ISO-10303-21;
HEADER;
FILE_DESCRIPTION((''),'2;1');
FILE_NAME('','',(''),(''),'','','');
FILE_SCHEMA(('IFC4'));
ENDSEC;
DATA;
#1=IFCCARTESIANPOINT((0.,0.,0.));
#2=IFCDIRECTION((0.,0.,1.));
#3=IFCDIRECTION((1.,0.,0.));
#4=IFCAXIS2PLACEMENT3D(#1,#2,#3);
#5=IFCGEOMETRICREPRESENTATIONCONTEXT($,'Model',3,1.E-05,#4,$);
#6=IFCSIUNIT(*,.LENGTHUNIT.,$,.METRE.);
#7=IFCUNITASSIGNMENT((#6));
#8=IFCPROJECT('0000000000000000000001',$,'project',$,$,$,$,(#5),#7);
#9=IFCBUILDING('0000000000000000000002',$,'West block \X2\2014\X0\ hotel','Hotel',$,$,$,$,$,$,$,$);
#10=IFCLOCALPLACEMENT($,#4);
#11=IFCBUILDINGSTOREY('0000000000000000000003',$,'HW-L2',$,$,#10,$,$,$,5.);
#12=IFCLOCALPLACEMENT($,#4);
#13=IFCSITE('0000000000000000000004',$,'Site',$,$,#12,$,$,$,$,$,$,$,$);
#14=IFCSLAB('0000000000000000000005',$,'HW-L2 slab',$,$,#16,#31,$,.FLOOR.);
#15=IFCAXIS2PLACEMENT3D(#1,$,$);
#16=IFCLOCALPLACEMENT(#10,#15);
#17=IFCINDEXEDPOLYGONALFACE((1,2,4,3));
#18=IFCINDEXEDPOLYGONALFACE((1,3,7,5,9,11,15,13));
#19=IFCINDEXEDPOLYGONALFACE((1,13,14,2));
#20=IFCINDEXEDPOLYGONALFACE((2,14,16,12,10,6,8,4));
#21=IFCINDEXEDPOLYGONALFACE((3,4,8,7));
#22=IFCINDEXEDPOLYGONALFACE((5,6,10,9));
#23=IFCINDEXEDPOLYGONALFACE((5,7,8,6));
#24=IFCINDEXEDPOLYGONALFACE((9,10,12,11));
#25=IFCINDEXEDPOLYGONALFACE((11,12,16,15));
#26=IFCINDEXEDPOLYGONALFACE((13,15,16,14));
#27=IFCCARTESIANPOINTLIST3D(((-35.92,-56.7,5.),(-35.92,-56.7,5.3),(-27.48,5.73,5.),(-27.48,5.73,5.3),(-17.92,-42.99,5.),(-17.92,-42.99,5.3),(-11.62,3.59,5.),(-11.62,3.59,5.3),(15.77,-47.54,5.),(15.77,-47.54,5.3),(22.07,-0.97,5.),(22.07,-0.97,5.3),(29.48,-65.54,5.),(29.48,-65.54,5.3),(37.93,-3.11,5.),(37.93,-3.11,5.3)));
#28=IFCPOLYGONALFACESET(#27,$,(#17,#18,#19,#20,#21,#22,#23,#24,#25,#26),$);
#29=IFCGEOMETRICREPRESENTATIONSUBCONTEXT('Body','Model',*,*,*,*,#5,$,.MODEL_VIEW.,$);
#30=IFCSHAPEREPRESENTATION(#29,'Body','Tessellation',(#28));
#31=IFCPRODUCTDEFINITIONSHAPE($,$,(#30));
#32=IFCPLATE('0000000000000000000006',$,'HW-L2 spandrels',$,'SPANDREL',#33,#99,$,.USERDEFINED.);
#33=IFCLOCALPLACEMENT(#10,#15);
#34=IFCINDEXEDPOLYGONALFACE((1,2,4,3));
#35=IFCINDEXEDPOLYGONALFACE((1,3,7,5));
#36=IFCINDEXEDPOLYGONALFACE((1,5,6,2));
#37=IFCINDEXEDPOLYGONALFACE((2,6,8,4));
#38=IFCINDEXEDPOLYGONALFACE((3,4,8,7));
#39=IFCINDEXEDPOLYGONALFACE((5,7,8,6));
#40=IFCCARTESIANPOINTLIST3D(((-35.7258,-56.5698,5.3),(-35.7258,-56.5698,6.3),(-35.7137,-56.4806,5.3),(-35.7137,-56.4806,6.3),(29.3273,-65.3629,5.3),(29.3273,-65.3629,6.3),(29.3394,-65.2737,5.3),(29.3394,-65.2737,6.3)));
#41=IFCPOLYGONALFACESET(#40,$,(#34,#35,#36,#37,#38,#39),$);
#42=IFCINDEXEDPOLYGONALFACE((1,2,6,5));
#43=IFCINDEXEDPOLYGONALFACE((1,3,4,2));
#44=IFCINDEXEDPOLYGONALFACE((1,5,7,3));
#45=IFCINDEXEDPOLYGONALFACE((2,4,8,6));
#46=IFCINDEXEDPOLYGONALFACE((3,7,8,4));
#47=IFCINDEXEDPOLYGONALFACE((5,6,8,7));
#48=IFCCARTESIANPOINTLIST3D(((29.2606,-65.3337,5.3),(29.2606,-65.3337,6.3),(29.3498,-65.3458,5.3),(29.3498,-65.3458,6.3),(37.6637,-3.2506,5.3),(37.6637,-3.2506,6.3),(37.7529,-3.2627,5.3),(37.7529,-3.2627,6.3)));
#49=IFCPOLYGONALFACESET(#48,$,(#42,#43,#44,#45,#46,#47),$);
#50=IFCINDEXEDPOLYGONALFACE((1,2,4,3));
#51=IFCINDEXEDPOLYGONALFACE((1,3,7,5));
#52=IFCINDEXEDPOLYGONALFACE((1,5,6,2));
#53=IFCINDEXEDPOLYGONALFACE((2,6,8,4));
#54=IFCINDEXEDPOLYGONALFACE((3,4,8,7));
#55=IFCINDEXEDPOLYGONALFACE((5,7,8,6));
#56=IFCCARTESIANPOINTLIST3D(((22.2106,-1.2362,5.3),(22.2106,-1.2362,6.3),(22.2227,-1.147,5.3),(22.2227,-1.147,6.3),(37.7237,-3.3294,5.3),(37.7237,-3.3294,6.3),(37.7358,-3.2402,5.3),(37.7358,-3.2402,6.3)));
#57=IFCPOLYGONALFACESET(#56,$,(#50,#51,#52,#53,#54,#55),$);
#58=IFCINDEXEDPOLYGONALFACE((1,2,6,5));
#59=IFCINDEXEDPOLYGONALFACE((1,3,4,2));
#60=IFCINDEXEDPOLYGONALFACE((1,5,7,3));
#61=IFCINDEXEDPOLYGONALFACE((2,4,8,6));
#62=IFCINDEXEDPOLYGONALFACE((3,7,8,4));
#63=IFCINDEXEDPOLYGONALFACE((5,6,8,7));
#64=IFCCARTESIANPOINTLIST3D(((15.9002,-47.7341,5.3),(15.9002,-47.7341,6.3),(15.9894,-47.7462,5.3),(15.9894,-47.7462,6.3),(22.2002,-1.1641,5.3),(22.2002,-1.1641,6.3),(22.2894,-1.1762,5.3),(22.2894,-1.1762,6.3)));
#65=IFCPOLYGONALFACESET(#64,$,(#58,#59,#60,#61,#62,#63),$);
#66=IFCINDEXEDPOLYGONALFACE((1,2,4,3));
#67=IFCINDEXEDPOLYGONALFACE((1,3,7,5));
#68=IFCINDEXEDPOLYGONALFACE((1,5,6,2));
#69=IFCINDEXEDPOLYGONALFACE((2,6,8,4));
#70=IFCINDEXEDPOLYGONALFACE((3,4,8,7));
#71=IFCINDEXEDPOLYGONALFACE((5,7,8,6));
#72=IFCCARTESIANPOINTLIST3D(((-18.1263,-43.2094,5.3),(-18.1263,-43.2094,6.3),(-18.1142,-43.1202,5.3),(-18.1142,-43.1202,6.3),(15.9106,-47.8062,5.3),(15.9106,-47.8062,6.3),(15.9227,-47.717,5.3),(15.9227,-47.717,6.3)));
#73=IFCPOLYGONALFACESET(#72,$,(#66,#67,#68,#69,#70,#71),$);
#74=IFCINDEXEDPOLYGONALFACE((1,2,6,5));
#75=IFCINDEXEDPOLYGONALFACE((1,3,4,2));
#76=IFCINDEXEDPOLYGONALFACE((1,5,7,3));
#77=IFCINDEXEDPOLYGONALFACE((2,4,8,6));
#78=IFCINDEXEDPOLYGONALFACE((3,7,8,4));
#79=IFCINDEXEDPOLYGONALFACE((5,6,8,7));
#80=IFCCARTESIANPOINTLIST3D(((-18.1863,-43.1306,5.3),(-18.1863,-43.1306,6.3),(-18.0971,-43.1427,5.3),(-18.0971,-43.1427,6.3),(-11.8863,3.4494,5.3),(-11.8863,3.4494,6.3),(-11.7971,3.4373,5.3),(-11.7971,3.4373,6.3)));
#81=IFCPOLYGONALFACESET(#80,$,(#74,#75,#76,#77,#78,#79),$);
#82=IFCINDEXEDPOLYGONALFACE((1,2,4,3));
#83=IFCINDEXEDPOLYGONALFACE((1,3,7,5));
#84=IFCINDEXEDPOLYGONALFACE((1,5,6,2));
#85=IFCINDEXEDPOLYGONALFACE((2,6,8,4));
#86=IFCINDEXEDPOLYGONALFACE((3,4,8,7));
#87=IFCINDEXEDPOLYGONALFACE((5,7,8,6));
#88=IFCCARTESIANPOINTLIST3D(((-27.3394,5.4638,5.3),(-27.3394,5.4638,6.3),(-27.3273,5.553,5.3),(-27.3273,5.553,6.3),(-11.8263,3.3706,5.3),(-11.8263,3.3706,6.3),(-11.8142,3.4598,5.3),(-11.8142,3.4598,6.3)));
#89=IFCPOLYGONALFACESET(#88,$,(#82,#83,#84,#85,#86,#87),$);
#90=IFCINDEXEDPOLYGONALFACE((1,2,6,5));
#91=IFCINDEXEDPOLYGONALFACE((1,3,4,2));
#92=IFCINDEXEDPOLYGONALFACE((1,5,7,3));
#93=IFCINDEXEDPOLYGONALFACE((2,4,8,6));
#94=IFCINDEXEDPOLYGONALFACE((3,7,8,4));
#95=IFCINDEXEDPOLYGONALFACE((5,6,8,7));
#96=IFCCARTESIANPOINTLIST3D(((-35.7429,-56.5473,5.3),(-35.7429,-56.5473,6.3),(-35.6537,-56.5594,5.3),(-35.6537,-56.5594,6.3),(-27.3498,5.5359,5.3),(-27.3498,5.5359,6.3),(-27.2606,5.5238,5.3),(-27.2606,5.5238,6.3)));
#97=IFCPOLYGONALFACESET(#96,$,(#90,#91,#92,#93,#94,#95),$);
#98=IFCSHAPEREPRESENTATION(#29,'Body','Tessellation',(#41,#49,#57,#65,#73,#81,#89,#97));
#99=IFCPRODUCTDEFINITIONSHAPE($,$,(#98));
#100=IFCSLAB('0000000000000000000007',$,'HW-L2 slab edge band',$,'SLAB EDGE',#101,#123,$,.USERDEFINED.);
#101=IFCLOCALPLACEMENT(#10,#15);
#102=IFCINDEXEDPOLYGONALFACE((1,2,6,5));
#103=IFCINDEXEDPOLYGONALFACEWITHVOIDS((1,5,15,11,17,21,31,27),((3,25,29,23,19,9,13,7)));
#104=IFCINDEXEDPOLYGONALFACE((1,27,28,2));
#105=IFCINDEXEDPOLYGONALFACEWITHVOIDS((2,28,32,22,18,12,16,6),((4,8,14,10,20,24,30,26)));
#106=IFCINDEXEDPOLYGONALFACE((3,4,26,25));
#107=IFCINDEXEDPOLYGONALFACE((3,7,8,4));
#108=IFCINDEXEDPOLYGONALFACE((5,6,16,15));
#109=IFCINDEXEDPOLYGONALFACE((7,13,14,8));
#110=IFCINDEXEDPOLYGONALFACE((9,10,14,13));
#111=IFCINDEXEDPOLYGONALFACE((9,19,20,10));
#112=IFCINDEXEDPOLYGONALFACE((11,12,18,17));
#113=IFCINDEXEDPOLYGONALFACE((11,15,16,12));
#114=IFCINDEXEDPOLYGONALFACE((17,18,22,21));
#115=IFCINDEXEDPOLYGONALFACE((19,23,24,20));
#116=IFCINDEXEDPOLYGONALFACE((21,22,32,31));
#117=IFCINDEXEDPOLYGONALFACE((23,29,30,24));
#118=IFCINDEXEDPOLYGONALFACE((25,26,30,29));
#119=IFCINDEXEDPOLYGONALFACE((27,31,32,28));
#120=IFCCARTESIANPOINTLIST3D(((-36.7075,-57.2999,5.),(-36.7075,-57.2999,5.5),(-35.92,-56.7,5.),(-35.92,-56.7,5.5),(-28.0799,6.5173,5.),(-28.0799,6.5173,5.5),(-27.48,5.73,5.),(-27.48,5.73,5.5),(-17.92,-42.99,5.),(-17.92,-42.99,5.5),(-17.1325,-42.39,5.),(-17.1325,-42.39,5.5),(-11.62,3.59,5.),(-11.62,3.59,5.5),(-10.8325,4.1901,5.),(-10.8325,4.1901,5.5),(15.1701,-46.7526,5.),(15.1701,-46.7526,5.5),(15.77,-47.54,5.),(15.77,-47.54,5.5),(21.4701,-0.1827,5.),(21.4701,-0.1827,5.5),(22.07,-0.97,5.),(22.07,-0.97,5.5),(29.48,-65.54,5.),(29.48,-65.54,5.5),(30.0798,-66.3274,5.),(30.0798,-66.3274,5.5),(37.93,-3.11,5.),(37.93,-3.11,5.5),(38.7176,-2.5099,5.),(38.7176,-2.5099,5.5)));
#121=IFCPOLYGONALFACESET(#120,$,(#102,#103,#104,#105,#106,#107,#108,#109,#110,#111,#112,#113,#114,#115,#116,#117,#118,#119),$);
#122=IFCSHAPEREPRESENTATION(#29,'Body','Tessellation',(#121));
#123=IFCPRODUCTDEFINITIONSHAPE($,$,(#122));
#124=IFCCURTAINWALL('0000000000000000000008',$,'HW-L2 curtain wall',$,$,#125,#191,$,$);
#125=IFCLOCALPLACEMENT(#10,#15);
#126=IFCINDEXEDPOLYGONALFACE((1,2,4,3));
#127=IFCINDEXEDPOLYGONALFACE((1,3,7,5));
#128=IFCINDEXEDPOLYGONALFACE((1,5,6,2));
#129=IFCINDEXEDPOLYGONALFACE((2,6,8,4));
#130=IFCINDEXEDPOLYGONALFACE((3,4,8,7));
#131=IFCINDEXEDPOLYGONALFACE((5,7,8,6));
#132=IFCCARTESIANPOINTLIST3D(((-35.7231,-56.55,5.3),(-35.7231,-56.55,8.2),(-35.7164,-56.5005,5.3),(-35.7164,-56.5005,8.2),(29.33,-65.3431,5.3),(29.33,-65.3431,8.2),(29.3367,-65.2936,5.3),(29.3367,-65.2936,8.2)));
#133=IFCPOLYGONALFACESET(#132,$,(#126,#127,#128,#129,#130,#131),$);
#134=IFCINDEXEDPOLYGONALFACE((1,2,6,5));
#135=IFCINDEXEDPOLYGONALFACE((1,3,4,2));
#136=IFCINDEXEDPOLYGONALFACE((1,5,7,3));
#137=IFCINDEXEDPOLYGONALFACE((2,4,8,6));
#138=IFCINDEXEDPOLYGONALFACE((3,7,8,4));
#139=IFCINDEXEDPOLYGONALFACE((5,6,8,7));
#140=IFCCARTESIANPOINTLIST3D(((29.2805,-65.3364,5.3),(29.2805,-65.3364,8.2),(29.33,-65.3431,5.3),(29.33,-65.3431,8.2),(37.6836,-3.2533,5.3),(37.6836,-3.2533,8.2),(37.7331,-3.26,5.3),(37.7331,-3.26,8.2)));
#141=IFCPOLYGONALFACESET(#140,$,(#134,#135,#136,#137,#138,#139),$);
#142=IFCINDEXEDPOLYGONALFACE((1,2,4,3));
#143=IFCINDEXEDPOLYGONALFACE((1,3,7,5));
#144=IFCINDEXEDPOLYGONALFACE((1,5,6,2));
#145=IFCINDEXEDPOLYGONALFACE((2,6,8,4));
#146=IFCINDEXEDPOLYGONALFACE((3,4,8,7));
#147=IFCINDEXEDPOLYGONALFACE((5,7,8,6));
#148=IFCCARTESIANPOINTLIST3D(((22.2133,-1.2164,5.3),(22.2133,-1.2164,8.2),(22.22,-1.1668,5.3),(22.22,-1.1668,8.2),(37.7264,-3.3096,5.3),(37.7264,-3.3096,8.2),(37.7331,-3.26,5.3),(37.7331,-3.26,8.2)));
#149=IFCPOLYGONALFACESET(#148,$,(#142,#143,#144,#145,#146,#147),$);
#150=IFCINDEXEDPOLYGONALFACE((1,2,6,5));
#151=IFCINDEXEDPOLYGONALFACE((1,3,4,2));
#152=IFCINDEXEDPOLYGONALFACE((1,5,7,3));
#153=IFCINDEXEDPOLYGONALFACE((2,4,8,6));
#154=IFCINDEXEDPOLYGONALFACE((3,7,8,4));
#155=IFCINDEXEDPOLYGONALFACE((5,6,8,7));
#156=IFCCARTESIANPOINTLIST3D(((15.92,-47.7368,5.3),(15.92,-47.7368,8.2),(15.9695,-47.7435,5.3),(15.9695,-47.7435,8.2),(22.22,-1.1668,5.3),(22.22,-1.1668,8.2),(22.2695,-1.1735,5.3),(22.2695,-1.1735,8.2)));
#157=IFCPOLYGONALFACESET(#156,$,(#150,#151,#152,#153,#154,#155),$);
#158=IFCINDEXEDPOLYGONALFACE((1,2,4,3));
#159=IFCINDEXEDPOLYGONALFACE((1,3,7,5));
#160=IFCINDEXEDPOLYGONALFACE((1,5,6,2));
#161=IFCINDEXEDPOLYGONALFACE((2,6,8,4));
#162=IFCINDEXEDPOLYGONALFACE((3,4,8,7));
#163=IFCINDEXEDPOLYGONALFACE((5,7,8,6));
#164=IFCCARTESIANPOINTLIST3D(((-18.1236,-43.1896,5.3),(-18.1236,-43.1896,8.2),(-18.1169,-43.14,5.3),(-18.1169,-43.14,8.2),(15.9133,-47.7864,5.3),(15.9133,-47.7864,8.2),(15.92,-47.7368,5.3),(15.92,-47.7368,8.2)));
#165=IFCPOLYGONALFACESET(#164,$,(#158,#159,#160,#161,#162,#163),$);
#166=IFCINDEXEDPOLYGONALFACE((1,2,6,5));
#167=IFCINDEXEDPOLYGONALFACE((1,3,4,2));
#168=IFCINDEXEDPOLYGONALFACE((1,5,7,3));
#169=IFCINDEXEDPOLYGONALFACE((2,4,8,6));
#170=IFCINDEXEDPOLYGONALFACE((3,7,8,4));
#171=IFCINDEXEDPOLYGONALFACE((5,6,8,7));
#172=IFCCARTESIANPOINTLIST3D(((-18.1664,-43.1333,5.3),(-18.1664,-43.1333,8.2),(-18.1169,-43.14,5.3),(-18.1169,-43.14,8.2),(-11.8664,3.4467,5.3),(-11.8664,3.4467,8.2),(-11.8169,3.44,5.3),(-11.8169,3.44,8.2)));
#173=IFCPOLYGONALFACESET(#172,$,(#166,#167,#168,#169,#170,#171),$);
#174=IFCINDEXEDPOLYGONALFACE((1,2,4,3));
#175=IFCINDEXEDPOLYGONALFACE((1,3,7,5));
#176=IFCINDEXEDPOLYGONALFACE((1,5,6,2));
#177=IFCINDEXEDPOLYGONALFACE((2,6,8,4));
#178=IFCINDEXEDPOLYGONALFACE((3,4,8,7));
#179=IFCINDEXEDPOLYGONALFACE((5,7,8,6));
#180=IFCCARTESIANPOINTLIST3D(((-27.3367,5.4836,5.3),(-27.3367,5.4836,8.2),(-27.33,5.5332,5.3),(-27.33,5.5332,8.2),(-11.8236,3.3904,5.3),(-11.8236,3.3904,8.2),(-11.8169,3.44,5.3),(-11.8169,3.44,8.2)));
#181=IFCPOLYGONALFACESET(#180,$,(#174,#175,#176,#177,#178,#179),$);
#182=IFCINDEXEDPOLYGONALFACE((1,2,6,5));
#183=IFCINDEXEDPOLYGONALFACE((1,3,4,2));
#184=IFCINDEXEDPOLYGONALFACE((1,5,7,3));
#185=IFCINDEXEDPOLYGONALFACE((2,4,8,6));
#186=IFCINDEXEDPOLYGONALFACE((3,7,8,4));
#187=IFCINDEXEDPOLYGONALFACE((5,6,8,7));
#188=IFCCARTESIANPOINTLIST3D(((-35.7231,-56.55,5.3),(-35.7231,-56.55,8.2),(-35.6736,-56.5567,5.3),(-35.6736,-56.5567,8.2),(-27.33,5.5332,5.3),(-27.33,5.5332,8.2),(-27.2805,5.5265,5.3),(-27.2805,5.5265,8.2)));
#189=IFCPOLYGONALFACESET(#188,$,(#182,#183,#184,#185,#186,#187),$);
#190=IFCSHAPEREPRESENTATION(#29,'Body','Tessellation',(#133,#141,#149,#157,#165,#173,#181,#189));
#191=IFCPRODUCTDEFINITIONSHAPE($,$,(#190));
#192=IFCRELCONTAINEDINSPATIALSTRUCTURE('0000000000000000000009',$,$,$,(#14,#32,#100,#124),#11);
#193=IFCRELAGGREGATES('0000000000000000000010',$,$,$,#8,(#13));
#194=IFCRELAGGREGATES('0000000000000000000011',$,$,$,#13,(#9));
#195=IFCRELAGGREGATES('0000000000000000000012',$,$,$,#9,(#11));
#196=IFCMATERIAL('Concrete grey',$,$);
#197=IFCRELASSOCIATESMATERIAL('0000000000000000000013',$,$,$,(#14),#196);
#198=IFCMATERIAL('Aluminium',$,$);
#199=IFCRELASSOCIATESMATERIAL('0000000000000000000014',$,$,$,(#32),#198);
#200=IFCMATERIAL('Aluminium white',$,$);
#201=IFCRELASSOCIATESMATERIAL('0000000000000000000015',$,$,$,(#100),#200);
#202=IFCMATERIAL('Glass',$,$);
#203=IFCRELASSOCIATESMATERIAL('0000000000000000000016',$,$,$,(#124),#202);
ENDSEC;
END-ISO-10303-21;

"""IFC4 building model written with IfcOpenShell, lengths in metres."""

from ifc_helpers import new_model, si_unit, frame, origin_with_axes, place, context, subcontext, project, spatial, polyline, outline, extrude, material, element, save


model = new_model("IFC4")

# Units and contexts
model_context = context("Model", 3, precision=1e-05, world=origin_with_axes())
body_context = subcontext(model_context, "Body", "Model", "MODEL_VIEW")
ifc_project = project(units=[si_unit("LENGTHUNIT", "METRE")], contexts=[model_context])

# Site, building, storey
site_placement = place(None, origin_with_axes())
site = spatial("IfcSite", under=ifc_project, at=site_placement, Name="Site")
building = spatial("IfcBuilding", under=site, Name="West block — hotel", Description="Hotel")
storey_placement = place(None, origin_with_axes())
storey = spatial("IfcBuildingStorey", under=building, at=storey_placement, Name="HW-L2", Elevation=5.0)

# Shared definitions
ifc_material_1 = material(Name="Aluminium")

# Slab
ifc_material_2 = material(Name="Concrete grey")
slab_1_placement = place(storey_placement, origin_with_axes())
element("IfcSlab", 1, at=slab_1_placement, inside=storey, material=ifc_material_2, Name="HW-L2 slab", PredefinedType="FLOOR", context=body_context, shape_type="SweptSolid", body=[
    extrude(outline(polyline([(-35.92, -56.7), (29.48, -65.54), (37.93, -3.11), (22.07, -0.97), (15.77, -47.54), (-17.92, -42.99), (-11.62, 3.59), (-27.48, 5.73), (-35.92, -56.7)])), frame((0.0, 0.0, 5.0), z_axis=(0.0, 0.0, 1.0), x_axis=(1.0, 0.0, 0.0)), (0.0, 0.0, 1.0), 0.3),
])

# Plate
plate_placement = place(storey_placement, origin_with_axes())
element("IfcPlate", 2, at=plate_placement, inside=storey, material=ifc_material_1, Name="HW-L2 spandrels", ObjectType="SPANDREL", PredefinedType="USERDEFINED", context=body_context, shape_type="SweptSolid", body=[
    extrude(outline(polyline([(-35.7258, -56.5698), (29.3273, -65.3629), (29.3394, -65.2737), (-35.7137, -56.4806), (-35.7258, -56.5698)])), frame((0.0, 0.0, 5.3), z_axis=(0.0, 0.0, 1.0), x_axis=(1.0, 0.0, 0.0)), (0.0, 0.0, 1.0), 1.0),
    extrude(outline(polyline([(29.3498, -65.3458), (37.7529, -3.2627), (37.6637, -3.2506), (29.2606, -65.3337), (29.3498, -65.3458)])), frame((0.0, 0.0, 5.3), z_axis=(0.0, 0.0, 1.0), x_axis=(1.0, 0.0, 0.0)), (0.0, 0.0, 1.0), 1.0),
    extrude(outline(polyline([(37.7358, -3.2402), (22.2227, -1.147), (22.2106, -1.2362), (37.7237, -3.3294), (37.7358, -3.2402)])), frame((0.0, 0.0, 5.3), z_axis=(0.0, 0.0, 1.0), x_axis=(1.0, 0.0, 0.0)), (0.0, 0.0, 1.0), 1.0),
    extrude(outline(polyline([(22.2002, -1.1641), (15.9002, -47.7341), (15.9894, -47.7462), (22.2894, -1.1762), (22.2002, -1.1641)])), frame((0.0, 0.0, 5.3), z_axis=(0.0, 0.0, 1.0), x_axis=(1.0, 0.0, 0.0)), (0.0, 0.0, 1.0), 1.0),
    extrude(outline(polyline([(15.9227, -47.717), (-18.1142, -43.1202), (-18.1263, -43.2094), (15.9106, -47.8062), (15.9227, -47.717)])), frame((0.0, 0.0, 5.3), z_axis=(0.0, 0.0, 1.0), x_axis=(1.0, 0.0, 0.0)), (0.0, 0.0, 1.0), 1.0),
    extrude(outline(polyline([(-18.0971, -43.1427), (-11.7971, 3.4373), (-11.8863, 3.4494), (-18.1863, -43.1306), (-18.0971, -43.1427)])), frame((0.0, 0.0, 5.3), z_axis=(0.0, 0.0, 1.0), x_axis=(1.0, 0.0, 0.0)), (0.0, 0.0, 1.0), 1.0),
    extrude(outline(polyline([(-11.8142, 3.4598), (-27.3273, 5.553), (-27.3394, 5.4638), (-11.8263, 3.3706), (-11.8142, 3.4598)])), frame((0.0, 0.0, 5.3), z_axis=(0.0, 0.0, 1.0), x_axis=(1.0, 0.0, 0.0)), (0.0, 0.0, 1.0), 1.0),
    extrude(outline(polyline([(-27.3498, 5.5359), (-35.7429, -56.5473), (-35.6537, -56.5594), (-27.2606, 5.5238), (-27.3498, 5.5359)])), frame((0.0, 0.0, 5.3), z_axis=(0.0, 0.0, 1.0), x_axis=(1.0, 0.0, 0.0)), (0.0, 0.0, 1.0), 1.0),
])

# Slab
ifc_material_3 = material(Name="Aluminium white")
slab_2_placement = place(storey_placement, origin_with_axes())
element("IfcSlab", 3, at=slab_2_placement, inside=storey, material=ifc_material_3, Name="HW-L2 slab edge band", ObjectType="SLAB EDGE", PredefinedType="USERDEFINED", context=body_context, shape_type="SweptSolid", body=[
    extrude(outline(polyline([(-36.7075, -57.2999), (30.0798, -66.3274), (38.7176, -2.5099), (21.4701, -0.1827), (15.1701, -46.7526), (-17.1325, -42.39), (-10.8325, 4.1901), (-28.0799, 6.5173), (-36.7075, -57.2999)]), holes=[polyline([(-35.92, -56.7), (29.48, -65.54), (37.93, -3.11), (22.07, -0.97), (15.77, -47.54), (-17.92, -42.99), (-11.62, 3.59), (-27.48, 5.73), (-35.92, -56.7)])]), frame((0.0, 0.0, 5.0), z_axis=(0.0, 0.0, 1.0), x_axis=(1.0, 0.0, 0.0)), (0.0, 0.0, 1.0), 0.5),
])

# Curtain wall
ifc_material_4 = material(Name="Glass")
curtain_wall_placement = place(storey_placement, origin_with_axes())
element("IfcCurtainWall", 4, at=curtain_wall_placement, inside=storey, material=ifc_material_4, Name="HW-L2 curtain wall", context=body_context, shape_type="SweptSolid", body=[
    extrude(outline(polyline([(-35.7231, -56.55), (29.33, -65.3431), (29.3367, -65.2936), (-35.7164, -56.5005), (-35.7231, -56.55)])), frame((0.0, 0.0, 5.3), z_axis=(0.0, 0.0, 1.0), x_axis=(1.0, 0.0, 0.0)), (0.0, 0.0, 1.0), 2.9),
    extrude(outline(polyline([(29.33, -65.3431), (37.7331, -3.26), (37.6836, -3.2533), (29.2805, -65.3364), (29.33, -65.3431)])), frame((0.0, 0.0, 5.3), z_axis=(0.0, 0.0, 1.0), x_axis=(1.0, 0.0, 0.0)), (0.0, 0.0, 1.0), 2.9),
    extrude(outline(polyline([(37.7331, -3.26), (22.22, -1.1668), (22.2133, -1.2164), (37.7264, -3.3096), (37.7331, -3.26)])), frame((0.0, 0.0, 5.3), z_axis=(0.0, 0.0, 1.0), x_axis=(1.0, 0.0, 0.0)), (0.0, 0.0, 1.0), 2.9),
    extrude(outline(polyline([(22.22, -1.1668), (15.92, -47.7368), (15.9695, -47.7435), (22.2695, -1.1735), (22.22, -1.1668)])), frame((0.0, 0.0, 5.3), z_axis=(0.0, 0.0, 1.0), x_axis=(1.0, 0.0, 0.0)), (0.0, 0.0, 1.0), 2.9),
    extrude(outline(polyline([(15.92, -47.7368), (-18.1169, -43.14), (-18.1236, -43.1896), (15.9133, -47.7864), (15.92, -47.7368)])), frame((0.0, 0.0, 5.3), z_axis=(0.0, 0.0, 1.0), x_axis=(1.0, 0.0, 0.0)), (0.0, 0.0, 1.0), 2.9),
    extrude(outline(polyline([(-18.1169, -43.14), (-11.8169, 3.44), (-11.8664, 3.4467), (-18.1664, -43.1333), (-18.1169, -43.14)])), frame((0.0, 0.0, 5.3), z_axis=(0.0, 0.0, 1.0), x_axis=(1.0, 0.0, 0.0)), (0.0, 0.0, 1.0), 2.9),
    extrude(outline(polyline([(-11.8169, 3.44), (-27.33, 5.5332), (-27.3367, 5.4836), (-11.8236, 3.3904), (-11.8169, 3.44)])), frame((0.0, 0.0, 5.3), z_axis=(0.0, 0.0, 1.0), x_axis=(1.0, 0.0, 0.0)), (0.0, 0.0, 1.0), 2.9),
    extrude(outline(polyline([(-27.33, 5.5332), (-35.7231, -56.55), (-35.6736, -56.5567), (-27.2805, 5.5265), (-27.33, 5.5332)])), frame((0.0, 0.0, 5.3), z_axis=(0.0, 0.0, 1.0), x_axis=(1.0, 0.0, 0.0)), (0.0, 0.0, 1.0), 2.9),
])

save(model, "model.ifc")
